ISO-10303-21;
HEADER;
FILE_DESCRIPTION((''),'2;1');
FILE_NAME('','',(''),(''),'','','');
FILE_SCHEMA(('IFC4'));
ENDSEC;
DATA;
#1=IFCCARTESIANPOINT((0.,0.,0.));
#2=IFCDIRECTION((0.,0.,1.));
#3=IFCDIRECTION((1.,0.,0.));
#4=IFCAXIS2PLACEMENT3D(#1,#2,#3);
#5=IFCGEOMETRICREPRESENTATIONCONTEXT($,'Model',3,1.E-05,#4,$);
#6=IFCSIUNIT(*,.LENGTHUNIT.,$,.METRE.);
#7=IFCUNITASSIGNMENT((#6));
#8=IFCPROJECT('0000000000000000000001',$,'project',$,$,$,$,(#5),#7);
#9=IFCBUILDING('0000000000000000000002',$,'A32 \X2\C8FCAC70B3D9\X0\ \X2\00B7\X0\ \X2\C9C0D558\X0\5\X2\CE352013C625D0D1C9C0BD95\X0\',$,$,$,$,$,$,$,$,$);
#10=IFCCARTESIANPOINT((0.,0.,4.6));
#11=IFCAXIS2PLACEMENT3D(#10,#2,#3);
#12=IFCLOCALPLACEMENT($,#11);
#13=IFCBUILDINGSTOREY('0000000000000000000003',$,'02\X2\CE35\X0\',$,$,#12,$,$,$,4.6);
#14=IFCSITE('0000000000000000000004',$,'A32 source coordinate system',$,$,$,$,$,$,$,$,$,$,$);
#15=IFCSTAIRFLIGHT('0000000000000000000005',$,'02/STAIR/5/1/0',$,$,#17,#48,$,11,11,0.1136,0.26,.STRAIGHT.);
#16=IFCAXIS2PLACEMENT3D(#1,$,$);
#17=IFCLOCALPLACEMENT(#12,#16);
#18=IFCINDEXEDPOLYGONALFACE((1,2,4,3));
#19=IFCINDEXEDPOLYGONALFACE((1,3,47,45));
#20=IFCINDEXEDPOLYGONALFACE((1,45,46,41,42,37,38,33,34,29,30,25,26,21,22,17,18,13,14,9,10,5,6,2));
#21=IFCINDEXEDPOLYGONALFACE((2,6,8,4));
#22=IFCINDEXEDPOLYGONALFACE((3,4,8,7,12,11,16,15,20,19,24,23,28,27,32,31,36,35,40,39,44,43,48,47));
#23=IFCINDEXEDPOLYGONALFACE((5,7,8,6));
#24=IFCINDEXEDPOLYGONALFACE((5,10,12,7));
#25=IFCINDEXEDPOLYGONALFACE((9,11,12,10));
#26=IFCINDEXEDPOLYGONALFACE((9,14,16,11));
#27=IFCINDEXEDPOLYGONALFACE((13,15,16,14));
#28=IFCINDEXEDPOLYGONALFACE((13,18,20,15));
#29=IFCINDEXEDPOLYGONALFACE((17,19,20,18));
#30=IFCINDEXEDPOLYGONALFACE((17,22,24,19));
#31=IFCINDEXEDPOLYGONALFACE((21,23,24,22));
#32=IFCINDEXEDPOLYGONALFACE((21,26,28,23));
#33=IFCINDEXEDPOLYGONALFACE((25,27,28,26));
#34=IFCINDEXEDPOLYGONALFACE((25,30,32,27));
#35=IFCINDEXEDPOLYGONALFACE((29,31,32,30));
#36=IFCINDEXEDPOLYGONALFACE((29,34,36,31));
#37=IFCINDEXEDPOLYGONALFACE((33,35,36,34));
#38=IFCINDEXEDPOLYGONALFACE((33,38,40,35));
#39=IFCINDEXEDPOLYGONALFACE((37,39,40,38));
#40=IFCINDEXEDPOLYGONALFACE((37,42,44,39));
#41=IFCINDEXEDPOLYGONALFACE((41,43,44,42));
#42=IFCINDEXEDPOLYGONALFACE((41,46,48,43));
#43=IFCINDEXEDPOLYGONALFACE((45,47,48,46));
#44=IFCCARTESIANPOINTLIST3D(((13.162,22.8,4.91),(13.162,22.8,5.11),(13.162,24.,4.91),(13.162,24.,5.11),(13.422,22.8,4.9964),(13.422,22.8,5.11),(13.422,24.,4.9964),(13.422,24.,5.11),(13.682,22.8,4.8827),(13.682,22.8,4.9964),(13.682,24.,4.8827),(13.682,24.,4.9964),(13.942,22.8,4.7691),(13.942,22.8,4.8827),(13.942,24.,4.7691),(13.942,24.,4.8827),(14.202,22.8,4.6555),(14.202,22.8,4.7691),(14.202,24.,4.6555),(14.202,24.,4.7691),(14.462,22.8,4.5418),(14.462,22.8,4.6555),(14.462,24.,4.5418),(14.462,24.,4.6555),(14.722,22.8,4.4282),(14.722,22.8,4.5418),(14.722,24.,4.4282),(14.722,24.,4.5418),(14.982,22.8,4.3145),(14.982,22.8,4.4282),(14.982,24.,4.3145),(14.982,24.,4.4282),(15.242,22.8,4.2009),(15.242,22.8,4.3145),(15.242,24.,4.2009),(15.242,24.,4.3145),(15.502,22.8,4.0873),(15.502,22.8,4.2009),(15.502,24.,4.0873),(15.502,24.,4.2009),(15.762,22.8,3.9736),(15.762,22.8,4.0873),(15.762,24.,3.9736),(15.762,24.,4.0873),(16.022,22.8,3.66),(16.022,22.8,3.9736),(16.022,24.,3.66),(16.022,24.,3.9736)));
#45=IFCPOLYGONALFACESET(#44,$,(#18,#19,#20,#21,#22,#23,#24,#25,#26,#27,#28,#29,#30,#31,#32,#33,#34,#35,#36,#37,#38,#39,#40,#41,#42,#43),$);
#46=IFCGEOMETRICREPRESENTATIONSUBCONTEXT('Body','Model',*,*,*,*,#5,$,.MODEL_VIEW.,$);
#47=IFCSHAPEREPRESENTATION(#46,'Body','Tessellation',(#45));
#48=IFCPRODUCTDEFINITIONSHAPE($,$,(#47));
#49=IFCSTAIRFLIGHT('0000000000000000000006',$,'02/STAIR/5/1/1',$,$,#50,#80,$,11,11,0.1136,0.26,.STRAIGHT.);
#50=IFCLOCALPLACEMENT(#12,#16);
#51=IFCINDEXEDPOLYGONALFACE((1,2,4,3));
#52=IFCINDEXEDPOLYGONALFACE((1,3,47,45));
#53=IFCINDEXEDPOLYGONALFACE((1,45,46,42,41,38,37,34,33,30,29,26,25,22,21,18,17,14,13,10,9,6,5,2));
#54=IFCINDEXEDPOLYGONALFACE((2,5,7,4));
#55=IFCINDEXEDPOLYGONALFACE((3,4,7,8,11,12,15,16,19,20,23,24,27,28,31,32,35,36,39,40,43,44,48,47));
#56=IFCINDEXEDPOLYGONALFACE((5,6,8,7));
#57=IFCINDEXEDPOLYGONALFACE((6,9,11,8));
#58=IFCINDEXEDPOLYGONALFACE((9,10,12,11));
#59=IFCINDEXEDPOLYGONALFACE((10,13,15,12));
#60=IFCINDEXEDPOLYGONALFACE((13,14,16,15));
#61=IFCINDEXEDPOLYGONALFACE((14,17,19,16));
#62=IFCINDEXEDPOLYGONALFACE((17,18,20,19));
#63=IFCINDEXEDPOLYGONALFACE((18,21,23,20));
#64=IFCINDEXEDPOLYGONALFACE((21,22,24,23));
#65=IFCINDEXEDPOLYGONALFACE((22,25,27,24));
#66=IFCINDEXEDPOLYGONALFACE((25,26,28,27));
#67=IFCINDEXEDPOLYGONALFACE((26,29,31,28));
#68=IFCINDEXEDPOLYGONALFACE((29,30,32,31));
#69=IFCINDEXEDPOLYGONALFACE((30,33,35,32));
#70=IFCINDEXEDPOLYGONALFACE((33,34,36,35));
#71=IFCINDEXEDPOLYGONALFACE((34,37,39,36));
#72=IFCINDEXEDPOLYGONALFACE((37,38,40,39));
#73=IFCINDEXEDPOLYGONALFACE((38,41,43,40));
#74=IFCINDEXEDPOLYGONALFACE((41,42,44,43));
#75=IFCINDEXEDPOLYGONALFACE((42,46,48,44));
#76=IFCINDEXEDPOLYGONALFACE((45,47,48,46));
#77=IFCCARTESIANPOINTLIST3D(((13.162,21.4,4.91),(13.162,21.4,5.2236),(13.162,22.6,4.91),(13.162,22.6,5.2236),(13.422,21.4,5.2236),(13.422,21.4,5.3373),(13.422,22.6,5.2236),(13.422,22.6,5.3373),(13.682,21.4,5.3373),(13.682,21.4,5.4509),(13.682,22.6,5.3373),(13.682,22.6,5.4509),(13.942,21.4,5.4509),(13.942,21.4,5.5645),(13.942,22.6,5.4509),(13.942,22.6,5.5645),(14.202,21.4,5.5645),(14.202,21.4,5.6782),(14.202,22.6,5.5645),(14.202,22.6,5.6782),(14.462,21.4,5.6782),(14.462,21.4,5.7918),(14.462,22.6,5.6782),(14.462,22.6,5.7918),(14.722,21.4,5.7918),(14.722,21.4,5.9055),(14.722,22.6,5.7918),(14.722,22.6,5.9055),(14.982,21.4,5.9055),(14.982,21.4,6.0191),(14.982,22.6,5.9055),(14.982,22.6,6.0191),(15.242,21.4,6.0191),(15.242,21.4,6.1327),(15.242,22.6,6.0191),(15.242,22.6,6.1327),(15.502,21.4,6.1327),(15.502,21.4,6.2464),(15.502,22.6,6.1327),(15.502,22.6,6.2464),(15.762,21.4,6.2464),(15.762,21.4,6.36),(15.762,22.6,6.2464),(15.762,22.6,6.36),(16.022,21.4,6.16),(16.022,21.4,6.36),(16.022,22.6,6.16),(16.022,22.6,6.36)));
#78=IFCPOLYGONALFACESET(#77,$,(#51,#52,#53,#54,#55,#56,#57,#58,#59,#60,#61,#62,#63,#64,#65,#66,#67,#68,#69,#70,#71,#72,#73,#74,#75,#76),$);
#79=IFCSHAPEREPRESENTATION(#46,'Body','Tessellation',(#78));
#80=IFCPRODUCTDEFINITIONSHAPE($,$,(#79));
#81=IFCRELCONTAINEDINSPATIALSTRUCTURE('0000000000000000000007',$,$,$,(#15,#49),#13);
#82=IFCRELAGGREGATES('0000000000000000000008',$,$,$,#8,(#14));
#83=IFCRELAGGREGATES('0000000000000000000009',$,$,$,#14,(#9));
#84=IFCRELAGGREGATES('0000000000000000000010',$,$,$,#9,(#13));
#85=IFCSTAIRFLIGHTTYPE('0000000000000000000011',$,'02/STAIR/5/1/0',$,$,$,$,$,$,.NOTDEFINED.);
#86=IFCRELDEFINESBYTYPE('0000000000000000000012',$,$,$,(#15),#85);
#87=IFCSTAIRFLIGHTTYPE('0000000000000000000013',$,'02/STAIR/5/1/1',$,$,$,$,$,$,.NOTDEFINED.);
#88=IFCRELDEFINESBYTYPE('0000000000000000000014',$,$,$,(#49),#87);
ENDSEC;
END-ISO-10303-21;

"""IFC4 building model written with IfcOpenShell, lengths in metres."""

from ifc_helpers import new_model, si_unit, frame, origin, origin_with_axes, place, context, subcontext, project, spatial, polyline, outline, extrude, source, transform, mapped, type_object, type_shapes, element, save


model = new_model("IFC4")

# Units and contexts
model_context = context("Model", 3, precision=1e-05, world=origin_with_axes())
body_context = subcontext(model_context, "Body", "Model", "MODEL_VIEW")
ifc_project = project(units=[si_unit("LENGTHUNIT", "METRE")], contexts=[model_context])

# Site, building, storey
storey_placement = place(None, frame((0.0, 0.0, 4.6), z_axis=(0.0, 0.0, 1.0), x_axis=(1.0, 0.0, 0.0)))
site = spatial("IfcSite", under=ifc_project, Name="A32 source coordinate system")
building = spatial("IfcBuilding", under=site, Name="A32 주거동 · 지하5층–옥탑지붕")
storey = spatial("IfcBuildingStorey", under=building, at=storey_placement, Name="02층", Elevation=4.6)

# Stair flights
stair_flight_type_1 = type_object("IfcStairFlightType", Name="02/STAIR/5/1/0", PredefinedType="NOTDEFINED")
shared_shape_1 = source(origin(), body_context, "Body", "SweptSolid", [
    extrude(outline(polyline([(0.0, 3.66), (2.86, 4.91), (2.86, 5.11), (2.6, 5.11), (2.6, 4.9964), (2.34, 4.9964), (2.34, 4.8827), (2.08, 4.8827), (2.08, 4.7691), (1.82, 4.7691), (1.82, 4.6555), (1.56, 4.6555), (1.56, 4.5418), (1.3, 4.5418), (1.3, 4.4282), (1.04, 4.4282), (1.04, 4.3145), (0.78, 4.3145), (0.78, 4.2009), (0.52, 4.2009), (0.52, 4.0873), (0.26, 4.0873), (0.26, 3.9736), (0.0, 3.9736), (0.0, 3.66)])), frame((16.022, 22.8, 0.0), z_axis=(0.0, 1.0, 0.0), x_axis=(-1.0, 0.0, 0.0)), (0.0, 0.0, 1.0), 1.2),
])
type_shapes(stair_flight_type_1, [shared_shape_1])
stair_flight_1_placement = place(storey_placement, origin_with_axes())
element("IfcStairFlight", 1, at=stair_flight_1_placement, inside=storey, type_object=stair_flight_type_1, Name="02/STAIR/5/1/0", NumberOfRisers=11, NumberOfTreads=11, PredefinedType="STRAIGHT", RiserHeight=0.1136, TreadLength=0.26, context=body_context, shape_type="MappedRepresentation", body=[
    mapped(shared_shape_1, transform((0.0, 0.0, 0.0), scale=1.0)),
])
stair_flight_type_2 = type_object("IfcStairFlightType", Name="02/STAIR/5/1/1", PredefinedType="NOTDEFINED")
shared_shape_2 = source(origin(), body_context, "Body", "SweptSolid", [
    extrude(outline(polyline([(0.0, 4.91), (2.86, 6.16), (2.86, 6.36), (2.6, 6.36), (2.6, 6.2464), (2.34, 6.2464), (2.34, 6.1327), (2.08, 6.1327), (2.08, 6.0191), (1.82, 6.0191), (1.82, 5.9055), (1.56, 5.9055), (1.56, 5.7918), (1.3, 5.7918), (1.3, 5.6782), (1.04, 5.6782), (1.04, 5.5645), (0.78, 5.5645), (0.78, 5.4509), (0.52, 5.4509), (0.52, 5.3373), (0.26, 5.3373), (0.26, 5.2236), (0.0, 5.2236), (0.0, 4.91)])), frame((13.162, 22.6, 0.0), z_axis=(0.0, -1.0, 0.0), x_axis=(1.0, 0.0, 0.0)), (0.0, 0.0, 1.0), 1.2),
])
type_shapes(stair_flight_type_2, [shared_shape_2])
stair_flight_2_placement = place(storey_placement, origin_with_axes())
element("IfcStairFlight", 2, at=stair_flight_2_placement, inside=storey, type_object=stair_flight_type_2, Name="02/STAIR/5/1/1", NumberOfRisers=11, NumberOfTreads=11, PredefinedType="STRAIGHT", RiserHeight=0.1136, TreadLength=0.26, context=body_context, shape_type="MappedRepresentation", body=[
    mapped(shared_shape_2, transform((0.0, 0.0, 0.0), scale=1.0)),
])

save(model, "model.ifc")
